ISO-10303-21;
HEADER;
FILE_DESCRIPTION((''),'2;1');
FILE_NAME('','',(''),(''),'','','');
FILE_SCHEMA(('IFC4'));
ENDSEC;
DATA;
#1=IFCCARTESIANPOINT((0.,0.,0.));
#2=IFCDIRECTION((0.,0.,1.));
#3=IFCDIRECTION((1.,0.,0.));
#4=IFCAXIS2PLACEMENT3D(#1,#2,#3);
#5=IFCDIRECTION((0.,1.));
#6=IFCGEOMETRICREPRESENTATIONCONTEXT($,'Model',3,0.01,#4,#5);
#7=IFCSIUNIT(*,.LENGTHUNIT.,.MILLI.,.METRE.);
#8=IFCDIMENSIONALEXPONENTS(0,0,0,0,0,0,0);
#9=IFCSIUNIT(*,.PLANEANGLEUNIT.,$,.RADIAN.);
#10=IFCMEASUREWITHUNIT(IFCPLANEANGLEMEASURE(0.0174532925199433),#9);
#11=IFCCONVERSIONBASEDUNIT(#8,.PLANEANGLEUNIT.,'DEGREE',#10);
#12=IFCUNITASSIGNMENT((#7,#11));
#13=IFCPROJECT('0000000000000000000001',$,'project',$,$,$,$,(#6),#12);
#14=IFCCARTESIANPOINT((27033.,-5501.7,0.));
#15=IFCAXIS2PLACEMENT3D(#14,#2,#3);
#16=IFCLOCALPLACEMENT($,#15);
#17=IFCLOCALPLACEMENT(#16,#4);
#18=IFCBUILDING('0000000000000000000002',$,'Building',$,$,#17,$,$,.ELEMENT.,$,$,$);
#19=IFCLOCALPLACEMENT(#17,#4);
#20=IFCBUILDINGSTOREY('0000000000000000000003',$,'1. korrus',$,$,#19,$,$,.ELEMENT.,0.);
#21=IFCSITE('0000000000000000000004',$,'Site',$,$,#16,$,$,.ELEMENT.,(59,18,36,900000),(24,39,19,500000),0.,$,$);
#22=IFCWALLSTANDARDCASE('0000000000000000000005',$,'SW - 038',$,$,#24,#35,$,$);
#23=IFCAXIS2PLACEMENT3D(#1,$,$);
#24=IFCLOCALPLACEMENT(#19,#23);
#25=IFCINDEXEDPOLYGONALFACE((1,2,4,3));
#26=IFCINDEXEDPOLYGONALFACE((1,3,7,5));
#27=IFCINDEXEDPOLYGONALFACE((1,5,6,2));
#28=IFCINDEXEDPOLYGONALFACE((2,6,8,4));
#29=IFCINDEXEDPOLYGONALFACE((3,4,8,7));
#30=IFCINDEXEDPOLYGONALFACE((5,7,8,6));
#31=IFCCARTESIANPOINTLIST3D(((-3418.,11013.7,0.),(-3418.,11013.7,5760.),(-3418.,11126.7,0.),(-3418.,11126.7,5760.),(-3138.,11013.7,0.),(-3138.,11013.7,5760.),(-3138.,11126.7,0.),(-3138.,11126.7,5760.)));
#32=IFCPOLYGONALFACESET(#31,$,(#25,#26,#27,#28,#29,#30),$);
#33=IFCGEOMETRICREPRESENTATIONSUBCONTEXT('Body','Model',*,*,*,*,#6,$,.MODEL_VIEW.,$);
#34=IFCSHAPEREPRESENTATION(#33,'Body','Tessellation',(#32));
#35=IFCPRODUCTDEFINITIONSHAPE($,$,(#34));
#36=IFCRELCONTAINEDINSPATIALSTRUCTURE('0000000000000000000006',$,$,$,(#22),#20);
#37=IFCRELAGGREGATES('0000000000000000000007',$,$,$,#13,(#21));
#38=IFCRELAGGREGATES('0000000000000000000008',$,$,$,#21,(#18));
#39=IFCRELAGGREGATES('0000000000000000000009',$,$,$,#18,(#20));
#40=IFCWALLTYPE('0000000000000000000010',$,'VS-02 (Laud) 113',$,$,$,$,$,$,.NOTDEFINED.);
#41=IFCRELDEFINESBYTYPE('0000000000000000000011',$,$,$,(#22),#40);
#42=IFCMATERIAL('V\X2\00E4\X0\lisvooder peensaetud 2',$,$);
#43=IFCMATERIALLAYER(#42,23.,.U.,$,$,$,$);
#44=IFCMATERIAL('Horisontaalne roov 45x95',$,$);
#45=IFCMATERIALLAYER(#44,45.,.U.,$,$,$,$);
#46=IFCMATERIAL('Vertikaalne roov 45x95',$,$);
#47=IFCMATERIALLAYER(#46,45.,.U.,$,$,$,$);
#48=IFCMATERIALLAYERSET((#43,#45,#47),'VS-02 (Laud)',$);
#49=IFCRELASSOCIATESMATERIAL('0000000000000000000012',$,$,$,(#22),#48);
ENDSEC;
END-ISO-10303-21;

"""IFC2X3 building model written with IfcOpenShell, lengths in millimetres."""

from ifc_helpers import new_model, entity, si_unit, converted_unit, direction, frame, origin_with_axes, place, context, subcontext, project, spatial, polyline, outline, extrude, material, layer, layer_set, layer_usage, type_object, element, save


model = new_model("IFC2X3")

# Units and contexts
model_context = context("Model", 3, precision=0.01, world=origin_with_axes(), true_north=direction((0.0, 1.0)))
body_context = subcontext(model_context, "Body", "Model", "MODEL_VIEW")
ifc_project = project(units=[si_unit("LENGTHUNIT", "METRE", prefix="MILLI"), converted_unit("PLANEANGLEUNIT", "DEGREE", entity("IfcPlaneAngleMeasure", 0.0174532925199433), si_unit("PLANEANGLEUNIT", "RADIAN"), dimensions=[0, 0, 0, 0, 0, 0, 0])], contexts=[model_context])

# Site, building, storey
site_placement = place(None, frame((27033.0, -5501.7, 0.0), z_axis=(0.0, 0.0, 1.0), x_axis=(1.0, 0.0, 0.0)))
site = spatial("IfcSite", under=ifc_project, at=site_placement, Name="Site", CompositionType="ELEMENT", RefLatitude=(59, 18, 36, 900000), RefLongitude=(24, 39, 19, 500000), RefElevation=0.0)
building_placement = place(site_placement, origin_with_axes())
building = spatial("IfcBuilding", under=site, at=building_placement, Name="Building", CompositionType="ELEMENT")
storey_placement = place(building_placement, origin_with_axes())
storey = spatial("IfcBuildingStorey", under=building, at=storey_placement, Name="1. korrus", CompositionType="ELEMENT", Elevation=0.0)

# Wall
ifc_material_1 = material(Name="Välisvooder peensaetud 2")
ifc_layer_1 = layer(ifc_material_1, 23.0, ventilated="UNKNOWN")
ifc_material_2 = material(Name="Horisontaalne roov 45x95")
ifc_layer_2 = layer(ifc_material_2, 45.0, ventilated="UNKNOWN")
ifc_material_3 = material(Name="Vertikaalne roov 45x95")
ifc_layer_3 = layer(ifc_material_3, 45.0, ventilated="UNKNOWN")
ifc_layer_set_1 = layer_set([ifc_layer_1, ifc_layer_2, ifc_layer_3], Name="VS-02 (Laud)")
ifc_layer_usage_1 = layer_usage(ifc_layer_set_1, "AXIS2", "POSITIVE", -113.0)
wall_type_1 = type_object("IfcWallType", Name="VS-02 (Laud) 113", PredefinedType="NOTDEFINED")
wall_1_placement = place(storey_placement, frame((-3418.0, 11126.7, 0.0), z_axis=(0.0, 0.0, 1.0), x_axis=(1.0, 0.000001, 0.0)))
element("IfcWallStandardCase", 1, at=wall_1_placement, inside=storey, type_object=wall_type_1, material=ifc_layer_usage_1, Name="SW - 038", context=body_context, shape_type="SweptSolid", body=[
    extrude(outline(polyline([(0.0, -113.0), (280.0, -113.0), (280.0, 0.0), (0.0, 0.0), (0.0, -113.0)])), origin_with_axes(), (0.0, 0.0, 1.0), 5760.0),
])

save(model, "model.ifc")
